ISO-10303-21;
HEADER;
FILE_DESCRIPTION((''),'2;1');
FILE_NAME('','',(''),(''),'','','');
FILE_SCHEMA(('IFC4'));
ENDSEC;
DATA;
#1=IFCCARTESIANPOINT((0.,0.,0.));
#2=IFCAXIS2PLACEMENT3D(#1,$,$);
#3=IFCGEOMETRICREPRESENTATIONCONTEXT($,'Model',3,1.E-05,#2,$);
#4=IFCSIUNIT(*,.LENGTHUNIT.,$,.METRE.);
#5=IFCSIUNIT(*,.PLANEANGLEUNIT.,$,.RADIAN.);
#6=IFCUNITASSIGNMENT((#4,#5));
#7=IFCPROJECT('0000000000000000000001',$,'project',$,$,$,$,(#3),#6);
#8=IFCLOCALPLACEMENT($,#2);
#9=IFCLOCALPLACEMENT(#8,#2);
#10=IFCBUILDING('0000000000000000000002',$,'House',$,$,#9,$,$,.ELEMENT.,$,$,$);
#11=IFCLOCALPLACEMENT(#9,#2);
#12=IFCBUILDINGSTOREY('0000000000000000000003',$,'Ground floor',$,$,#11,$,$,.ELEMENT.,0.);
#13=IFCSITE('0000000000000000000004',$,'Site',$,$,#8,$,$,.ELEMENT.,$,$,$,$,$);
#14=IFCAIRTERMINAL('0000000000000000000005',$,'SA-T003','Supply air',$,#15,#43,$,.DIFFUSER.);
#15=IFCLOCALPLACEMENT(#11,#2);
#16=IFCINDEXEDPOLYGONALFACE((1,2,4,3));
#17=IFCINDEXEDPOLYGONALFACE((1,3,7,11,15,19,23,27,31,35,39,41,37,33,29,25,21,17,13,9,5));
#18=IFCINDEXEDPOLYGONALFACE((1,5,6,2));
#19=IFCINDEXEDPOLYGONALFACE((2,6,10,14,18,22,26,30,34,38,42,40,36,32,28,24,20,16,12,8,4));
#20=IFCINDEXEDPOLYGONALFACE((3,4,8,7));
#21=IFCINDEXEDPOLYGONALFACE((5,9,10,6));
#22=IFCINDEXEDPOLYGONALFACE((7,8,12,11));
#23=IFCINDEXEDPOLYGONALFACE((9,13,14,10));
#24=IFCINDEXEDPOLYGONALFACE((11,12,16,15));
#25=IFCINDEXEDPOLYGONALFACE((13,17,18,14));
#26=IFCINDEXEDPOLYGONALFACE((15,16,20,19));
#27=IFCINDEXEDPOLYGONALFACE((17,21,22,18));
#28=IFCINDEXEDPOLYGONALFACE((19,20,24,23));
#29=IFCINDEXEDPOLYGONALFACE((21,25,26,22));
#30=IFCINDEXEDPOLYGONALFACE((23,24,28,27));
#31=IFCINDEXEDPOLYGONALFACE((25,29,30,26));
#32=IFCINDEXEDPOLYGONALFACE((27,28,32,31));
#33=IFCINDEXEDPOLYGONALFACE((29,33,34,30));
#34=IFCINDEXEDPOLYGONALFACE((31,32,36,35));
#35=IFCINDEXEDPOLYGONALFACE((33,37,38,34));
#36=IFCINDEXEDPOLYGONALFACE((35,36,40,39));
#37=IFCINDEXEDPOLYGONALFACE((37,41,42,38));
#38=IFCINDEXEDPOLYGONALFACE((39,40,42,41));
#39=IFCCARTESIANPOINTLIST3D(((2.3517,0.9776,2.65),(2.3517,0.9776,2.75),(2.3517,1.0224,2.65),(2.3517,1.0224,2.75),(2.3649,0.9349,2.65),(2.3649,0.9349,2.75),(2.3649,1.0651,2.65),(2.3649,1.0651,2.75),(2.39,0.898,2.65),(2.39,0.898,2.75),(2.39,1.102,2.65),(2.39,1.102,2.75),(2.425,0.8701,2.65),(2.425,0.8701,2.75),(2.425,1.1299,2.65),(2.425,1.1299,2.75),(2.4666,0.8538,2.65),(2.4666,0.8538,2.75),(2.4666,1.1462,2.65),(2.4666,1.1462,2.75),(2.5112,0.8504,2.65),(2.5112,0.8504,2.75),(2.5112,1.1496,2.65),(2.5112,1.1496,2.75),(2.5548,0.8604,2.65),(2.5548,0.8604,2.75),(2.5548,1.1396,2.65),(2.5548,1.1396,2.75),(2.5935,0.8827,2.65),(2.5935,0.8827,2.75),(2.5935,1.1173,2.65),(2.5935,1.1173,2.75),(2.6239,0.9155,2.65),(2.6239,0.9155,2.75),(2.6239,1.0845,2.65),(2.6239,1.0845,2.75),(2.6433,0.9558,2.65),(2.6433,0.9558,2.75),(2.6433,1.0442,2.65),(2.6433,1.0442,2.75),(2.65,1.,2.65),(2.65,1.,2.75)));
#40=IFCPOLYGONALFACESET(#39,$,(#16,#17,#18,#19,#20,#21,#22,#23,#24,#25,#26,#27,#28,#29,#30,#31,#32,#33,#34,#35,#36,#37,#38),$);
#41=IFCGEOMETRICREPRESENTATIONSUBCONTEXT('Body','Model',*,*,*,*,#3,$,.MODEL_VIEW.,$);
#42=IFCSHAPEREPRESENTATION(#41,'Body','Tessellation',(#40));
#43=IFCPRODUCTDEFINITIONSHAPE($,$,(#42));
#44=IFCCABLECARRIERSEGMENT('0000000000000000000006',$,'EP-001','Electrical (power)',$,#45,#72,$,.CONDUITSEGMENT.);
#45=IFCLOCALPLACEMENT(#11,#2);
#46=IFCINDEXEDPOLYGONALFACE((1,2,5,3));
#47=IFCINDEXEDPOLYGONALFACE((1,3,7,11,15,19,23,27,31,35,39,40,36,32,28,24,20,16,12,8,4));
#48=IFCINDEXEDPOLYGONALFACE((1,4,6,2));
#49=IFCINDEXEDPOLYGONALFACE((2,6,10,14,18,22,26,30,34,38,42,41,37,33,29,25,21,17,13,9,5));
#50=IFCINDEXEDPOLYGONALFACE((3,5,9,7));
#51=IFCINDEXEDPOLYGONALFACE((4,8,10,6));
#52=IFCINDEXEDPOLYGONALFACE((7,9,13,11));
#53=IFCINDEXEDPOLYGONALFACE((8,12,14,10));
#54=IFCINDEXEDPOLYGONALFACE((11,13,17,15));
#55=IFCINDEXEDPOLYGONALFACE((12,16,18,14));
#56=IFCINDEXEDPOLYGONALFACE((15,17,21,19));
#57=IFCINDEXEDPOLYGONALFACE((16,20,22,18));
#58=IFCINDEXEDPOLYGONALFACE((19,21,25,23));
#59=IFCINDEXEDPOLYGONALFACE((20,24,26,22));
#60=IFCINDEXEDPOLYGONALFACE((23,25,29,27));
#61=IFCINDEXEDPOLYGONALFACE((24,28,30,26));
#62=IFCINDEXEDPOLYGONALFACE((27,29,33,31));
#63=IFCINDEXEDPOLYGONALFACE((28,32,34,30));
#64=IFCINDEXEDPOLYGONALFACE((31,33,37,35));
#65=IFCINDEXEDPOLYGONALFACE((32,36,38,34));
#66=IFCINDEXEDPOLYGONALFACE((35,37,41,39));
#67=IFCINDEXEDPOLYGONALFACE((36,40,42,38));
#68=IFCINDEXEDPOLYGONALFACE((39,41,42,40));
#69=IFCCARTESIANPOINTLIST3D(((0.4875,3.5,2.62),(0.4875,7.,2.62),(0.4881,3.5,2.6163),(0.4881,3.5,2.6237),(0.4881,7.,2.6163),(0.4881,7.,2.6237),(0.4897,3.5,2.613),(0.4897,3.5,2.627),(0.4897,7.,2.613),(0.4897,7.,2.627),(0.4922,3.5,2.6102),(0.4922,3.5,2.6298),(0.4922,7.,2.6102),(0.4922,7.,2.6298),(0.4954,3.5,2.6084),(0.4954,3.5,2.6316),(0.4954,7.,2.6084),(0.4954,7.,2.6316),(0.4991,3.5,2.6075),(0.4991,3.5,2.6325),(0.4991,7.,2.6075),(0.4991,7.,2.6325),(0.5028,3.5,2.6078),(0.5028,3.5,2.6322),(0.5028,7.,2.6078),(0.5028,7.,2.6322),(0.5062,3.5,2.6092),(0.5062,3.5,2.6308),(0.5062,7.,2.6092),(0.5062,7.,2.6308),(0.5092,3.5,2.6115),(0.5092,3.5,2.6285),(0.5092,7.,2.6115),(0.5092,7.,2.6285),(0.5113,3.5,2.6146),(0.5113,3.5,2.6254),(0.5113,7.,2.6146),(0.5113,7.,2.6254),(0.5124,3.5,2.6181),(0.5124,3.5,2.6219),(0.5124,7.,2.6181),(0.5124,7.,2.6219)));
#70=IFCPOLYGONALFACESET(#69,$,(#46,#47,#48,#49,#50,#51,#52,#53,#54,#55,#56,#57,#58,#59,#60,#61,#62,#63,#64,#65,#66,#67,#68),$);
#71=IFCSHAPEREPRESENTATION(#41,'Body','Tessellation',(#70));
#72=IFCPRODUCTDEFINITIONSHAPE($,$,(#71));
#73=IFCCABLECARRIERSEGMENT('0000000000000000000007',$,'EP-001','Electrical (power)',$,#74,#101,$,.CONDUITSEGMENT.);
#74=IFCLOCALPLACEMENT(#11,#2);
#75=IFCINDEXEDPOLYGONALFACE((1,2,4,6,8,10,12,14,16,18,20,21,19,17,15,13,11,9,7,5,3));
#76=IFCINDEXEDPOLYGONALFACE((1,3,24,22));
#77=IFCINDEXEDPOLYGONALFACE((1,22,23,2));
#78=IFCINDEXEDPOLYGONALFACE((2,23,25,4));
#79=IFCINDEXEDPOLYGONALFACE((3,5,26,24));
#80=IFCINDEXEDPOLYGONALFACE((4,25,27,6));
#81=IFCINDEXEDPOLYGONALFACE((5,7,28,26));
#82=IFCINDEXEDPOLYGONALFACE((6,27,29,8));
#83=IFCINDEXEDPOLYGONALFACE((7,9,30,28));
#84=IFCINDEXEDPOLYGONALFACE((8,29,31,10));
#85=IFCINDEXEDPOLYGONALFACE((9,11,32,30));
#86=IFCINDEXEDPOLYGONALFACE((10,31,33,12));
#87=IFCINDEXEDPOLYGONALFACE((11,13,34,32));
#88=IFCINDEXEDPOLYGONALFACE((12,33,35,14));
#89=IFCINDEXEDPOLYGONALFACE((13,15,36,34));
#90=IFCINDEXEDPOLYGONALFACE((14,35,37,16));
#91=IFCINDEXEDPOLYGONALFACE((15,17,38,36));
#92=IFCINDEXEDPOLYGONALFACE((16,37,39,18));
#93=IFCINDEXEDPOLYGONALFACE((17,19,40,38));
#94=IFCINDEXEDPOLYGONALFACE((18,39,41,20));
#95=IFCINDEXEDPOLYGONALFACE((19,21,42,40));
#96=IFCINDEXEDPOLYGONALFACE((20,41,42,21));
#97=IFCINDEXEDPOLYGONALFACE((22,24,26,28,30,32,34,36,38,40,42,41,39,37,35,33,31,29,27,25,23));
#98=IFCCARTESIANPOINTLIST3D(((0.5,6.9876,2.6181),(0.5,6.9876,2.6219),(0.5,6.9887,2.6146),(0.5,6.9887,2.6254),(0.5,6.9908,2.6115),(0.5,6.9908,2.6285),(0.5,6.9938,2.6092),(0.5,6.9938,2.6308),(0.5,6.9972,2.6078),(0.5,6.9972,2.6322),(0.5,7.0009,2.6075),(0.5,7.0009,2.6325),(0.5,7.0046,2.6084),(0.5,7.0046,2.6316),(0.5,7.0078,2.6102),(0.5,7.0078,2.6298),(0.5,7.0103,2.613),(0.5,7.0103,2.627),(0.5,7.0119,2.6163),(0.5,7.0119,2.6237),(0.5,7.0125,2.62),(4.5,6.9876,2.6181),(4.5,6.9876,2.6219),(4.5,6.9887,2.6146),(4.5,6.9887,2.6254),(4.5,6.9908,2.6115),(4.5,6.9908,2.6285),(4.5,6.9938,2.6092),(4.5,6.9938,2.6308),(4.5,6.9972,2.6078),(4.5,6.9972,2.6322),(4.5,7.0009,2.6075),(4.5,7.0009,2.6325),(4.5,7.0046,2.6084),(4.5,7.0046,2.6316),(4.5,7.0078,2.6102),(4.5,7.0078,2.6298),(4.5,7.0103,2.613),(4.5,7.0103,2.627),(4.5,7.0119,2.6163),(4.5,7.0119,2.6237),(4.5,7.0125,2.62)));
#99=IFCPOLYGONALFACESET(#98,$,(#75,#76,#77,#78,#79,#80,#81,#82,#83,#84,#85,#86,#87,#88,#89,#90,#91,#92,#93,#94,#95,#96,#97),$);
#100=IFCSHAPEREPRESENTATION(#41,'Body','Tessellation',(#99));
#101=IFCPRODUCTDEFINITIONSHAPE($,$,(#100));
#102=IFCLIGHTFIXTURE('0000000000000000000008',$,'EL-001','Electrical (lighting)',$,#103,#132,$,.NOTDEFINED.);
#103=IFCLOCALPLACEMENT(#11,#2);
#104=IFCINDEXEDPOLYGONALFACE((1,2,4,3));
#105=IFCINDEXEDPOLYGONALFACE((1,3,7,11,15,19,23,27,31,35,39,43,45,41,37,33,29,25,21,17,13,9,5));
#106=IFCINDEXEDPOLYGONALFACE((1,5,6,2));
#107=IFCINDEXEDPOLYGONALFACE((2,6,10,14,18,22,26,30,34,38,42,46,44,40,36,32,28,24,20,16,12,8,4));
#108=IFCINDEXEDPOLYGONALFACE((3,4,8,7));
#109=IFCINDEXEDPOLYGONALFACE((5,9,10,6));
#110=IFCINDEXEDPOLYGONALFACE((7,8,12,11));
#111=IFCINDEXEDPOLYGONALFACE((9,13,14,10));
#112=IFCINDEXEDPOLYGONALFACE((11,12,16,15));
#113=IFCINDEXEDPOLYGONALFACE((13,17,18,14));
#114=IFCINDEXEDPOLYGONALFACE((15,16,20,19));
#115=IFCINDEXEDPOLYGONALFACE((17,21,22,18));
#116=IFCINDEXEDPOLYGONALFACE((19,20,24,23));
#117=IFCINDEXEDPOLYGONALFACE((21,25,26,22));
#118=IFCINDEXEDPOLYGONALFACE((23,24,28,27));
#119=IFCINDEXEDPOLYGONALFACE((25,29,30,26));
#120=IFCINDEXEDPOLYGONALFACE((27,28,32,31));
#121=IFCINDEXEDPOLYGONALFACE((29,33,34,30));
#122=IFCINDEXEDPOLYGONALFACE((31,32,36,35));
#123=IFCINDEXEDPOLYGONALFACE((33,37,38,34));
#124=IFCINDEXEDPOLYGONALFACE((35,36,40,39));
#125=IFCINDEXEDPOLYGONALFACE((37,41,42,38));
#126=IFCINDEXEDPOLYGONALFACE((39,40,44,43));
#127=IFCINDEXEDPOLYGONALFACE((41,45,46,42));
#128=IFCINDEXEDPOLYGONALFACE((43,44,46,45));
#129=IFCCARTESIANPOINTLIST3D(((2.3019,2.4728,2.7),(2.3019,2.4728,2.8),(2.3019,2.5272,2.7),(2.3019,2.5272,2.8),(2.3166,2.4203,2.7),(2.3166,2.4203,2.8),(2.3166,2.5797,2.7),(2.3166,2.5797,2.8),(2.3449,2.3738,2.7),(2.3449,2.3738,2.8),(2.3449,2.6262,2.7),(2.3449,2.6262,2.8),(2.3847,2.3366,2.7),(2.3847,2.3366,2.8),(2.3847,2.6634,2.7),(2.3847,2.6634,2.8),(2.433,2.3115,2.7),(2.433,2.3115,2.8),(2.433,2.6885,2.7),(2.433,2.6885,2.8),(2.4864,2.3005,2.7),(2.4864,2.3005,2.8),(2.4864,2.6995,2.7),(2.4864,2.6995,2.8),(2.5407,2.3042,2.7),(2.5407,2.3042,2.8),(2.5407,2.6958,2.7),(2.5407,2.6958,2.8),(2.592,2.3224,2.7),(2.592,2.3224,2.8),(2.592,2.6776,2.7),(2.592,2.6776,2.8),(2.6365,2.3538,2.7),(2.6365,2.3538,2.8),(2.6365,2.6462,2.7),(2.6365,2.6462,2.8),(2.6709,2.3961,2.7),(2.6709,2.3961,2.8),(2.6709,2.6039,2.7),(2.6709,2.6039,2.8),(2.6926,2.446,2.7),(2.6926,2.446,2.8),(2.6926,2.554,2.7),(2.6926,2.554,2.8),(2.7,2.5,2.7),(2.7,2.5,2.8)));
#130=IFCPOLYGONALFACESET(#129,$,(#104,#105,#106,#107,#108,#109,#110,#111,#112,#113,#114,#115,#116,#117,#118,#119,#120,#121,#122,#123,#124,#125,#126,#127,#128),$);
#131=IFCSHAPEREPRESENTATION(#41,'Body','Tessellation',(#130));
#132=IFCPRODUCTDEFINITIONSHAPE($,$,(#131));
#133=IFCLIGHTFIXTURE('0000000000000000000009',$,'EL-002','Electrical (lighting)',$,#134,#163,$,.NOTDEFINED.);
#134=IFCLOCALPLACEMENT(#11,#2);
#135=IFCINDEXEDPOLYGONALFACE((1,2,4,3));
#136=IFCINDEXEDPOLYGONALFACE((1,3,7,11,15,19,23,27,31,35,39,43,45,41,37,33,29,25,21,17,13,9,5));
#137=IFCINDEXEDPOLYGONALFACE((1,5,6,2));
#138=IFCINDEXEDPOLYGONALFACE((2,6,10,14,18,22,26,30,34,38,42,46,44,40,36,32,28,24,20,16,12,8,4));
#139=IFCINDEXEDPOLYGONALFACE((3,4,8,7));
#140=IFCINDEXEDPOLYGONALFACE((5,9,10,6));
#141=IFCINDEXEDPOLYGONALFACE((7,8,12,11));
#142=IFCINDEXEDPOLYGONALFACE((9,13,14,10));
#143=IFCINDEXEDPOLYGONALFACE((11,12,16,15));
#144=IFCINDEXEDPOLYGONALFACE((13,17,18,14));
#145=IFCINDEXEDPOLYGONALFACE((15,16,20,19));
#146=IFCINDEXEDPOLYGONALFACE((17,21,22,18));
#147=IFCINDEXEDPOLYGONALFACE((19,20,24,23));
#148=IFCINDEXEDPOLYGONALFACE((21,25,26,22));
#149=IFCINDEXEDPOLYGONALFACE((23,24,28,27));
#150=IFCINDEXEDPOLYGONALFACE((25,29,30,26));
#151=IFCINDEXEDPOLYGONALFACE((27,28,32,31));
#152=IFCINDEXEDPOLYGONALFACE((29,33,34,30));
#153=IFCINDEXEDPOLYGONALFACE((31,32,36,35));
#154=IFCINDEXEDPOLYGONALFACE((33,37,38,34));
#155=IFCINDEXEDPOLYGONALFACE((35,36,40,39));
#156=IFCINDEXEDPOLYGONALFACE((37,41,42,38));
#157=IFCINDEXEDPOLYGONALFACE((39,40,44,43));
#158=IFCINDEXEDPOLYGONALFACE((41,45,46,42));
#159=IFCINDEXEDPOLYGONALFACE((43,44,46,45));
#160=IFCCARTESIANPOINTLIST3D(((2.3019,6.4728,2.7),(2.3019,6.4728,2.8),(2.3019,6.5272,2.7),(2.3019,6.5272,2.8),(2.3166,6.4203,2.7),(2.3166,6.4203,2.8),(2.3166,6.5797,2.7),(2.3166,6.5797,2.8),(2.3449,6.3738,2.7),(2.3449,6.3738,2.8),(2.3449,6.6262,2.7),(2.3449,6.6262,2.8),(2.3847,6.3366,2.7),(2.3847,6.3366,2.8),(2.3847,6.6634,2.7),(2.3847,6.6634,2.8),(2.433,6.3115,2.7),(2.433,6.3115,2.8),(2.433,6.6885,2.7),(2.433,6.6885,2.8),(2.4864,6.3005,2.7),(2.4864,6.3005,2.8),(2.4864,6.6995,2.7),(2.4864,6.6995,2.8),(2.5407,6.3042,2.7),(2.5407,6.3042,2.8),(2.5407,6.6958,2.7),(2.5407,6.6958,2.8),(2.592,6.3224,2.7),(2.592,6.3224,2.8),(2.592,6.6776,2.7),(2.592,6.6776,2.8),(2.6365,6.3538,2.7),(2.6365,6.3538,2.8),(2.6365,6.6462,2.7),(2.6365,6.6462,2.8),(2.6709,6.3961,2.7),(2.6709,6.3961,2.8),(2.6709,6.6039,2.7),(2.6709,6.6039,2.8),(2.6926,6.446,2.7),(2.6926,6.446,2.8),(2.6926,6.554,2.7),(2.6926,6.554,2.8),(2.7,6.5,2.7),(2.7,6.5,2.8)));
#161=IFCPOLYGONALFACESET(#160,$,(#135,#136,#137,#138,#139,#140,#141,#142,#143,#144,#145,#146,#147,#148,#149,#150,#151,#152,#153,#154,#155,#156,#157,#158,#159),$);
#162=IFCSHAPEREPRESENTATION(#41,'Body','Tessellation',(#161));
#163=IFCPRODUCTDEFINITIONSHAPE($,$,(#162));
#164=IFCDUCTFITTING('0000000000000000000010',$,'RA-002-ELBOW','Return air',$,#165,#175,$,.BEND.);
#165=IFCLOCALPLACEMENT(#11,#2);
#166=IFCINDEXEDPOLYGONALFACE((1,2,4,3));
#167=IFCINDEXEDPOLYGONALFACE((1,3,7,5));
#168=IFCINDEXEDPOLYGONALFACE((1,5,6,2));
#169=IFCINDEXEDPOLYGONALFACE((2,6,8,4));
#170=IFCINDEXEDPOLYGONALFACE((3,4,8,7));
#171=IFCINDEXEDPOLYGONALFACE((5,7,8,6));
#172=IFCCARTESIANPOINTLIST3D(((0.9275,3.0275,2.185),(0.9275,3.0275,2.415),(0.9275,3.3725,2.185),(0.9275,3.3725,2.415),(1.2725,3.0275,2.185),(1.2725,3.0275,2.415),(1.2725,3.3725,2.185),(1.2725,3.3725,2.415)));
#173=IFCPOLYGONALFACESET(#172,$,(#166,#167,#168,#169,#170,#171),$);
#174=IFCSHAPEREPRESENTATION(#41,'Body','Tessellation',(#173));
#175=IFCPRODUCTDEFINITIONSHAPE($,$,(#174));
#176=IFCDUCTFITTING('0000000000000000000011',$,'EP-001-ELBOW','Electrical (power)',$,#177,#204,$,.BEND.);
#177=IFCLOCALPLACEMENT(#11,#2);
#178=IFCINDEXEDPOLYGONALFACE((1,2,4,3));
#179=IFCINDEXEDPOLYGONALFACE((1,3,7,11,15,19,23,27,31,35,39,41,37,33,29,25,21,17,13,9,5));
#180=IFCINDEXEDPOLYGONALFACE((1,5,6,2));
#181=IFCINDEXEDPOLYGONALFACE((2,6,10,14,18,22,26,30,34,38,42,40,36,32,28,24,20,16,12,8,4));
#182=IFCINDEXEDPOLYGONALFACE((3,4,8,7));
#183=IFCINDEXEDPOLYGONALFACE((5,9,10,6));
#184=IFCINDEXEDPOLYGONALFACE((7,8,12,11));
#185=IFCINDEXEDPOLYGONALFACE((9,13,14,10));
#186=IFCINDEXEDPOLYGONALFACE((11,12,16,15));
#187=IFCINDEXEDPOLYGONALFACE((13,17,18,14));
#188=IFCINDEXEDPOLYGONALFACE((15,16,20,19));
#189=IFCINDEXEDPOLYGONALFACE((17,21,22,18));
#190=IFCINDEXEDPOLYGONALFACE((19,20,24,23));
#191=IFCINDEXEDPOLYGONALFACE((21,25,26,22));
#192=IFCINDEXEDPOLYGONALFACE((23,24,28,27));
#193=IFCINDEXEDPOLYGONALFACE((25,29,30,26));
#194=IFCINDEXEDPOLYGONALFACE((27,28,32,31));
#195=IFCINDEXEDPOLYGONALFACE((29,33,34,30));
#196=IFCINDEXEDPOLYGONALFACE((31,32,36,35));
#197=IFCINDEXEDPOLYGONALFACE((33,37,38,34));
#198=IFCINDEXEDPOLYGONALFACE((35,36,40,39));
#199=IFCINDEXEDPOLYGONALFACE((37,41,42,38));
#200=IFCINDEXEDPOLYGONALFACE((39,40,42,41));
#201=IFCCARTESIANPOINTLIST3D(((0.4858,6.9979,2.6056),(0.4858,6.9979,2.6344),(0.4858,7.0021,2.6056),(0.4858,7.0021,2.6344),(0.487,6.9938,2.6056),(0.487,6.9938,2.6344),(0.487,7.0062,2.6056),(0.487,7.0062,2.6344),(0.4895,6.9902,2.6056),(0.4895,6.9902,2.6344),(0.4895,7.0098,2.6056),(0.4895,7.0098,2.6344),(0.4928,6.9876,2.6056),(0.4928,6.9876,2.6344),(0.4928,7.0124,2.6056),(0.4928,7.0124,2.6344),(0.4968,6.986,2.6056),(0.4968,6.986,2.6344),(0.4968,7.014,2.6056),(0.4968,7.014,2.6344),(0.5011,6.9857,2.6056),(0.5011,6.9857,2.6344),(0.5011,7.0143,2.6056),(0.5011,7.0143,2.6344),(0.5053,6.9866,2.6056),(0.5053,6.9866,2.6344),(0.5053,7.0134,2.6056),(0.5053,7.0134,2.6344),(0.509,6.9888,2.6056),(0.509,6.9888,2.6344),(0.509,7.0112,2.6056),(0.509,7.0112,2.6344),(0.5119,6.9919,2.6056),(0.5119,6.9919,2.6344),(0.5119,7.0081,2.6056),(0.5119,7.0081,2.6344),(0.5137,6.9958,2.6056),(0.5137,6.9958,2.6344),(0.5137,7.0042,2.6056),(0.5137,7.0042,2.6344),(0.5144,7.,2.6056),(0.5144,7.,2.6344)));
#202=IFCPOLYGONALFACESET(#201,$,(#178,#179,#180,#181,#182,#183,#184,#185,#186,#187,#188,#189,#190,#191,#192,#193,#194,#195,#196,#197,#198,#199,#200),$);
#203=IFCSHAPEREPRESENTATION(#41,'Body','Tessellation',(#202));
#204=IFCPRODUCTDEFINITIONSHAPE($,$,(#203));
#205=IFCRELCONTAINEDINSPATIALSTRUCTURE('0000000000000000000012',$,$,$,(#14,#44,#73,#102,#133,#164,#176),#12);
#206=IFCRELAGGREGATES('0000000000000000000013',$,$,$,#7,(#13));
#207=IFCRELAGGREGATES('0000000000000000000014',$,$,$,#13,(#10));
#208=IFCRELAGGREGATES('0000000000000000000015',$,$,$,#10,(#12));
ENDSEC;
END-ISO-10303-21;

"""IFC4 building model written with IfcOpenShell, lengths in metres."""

from ifc_helpers import new_model, si_unit, frame, origin, origin_2d, place, context, subcontext, project, spatial, rectangle, circle, extrude, element, save


model = new_model("IFC4")

# Units and contexts
model_context = context("Model", 3, precision=1e-05, world=origin())
body_context = subcontext(model_context, "Body", "Model", "MODEL_VIEW")
ifc_project = project(units=[si_unit("LENGTHUNIT", "METRE"), si_unit("PLANEANGLEUNIT", "RADIAN")], contexts=[model_context])

# Site, building, storey
site_placement = place(None, origin())
site = spatial("IfcSite", under=ifc_project, at=site_placement, Name="Site", CompositionType="ELEMENT")
building_placement = place(site_placement, origin())
building = spatial("IfcBuilding", under=site, at=building_placement, Name="House", CompositionType="ELEMENT")
storey_placement = place(building_placement, origin())
storey = spatial("IfcBuildingStorey", under=building, at=storey_placement, Name="Ground floor", CompositionType="ELEMENT", Elevation=0.0)

# Air terminal
air_terminal_placement = place(storey_placement, frame((2.5, 1.0, 2.65), z_axis=(0.0, 0.0, 1.0), x_axis=(1.0, 0.0, 0.0)))
element("IfcAirTerminal", 1, at=air_terminal_placement, inside=storey, Name="SA-T003", Description="Supply air", PredefinedType="DIFFUSER", context=body_context, shape_type="SweptSolid", body=[
    extrude(circle(Radius=0.15, at=origin_2d()), origin(), (0.0, 0.0, 1.0), 0.1),
])

# Cable carrier segments
cable_carrier_segment_1_placement = place(storey_placement, frame((0.5, 3.5, 2.62), z_axis=(0.0, 1.0, 0.0), x_axis=(-1.0, 0.0, 0.0)))
element("IfcCableCarrierSegment", 2, at=cable_carrier_segment_1_placement, inside=storey, Name="EP-001", Description="Electrical (power)", PredefinedType="CONDUITSEGMENT", context=body_context, shape_type="SweptSolid", body=[
    extrude(circle(Radius=0.0125, at=origin_2d()), origin(), (0.0, 0.0, 1.0), 3.5),
])
cable_carrier_segment_2_placement = place(storey_placement, frame((0.5, 7.0, 2.62), z_axis=(1.0, 0.0, 0.0), x_axis=(0.0, 1.0, 0.0)))
element("IfcCableCarrierSegment", 3, at=cable_carrier_segment_2_placement, inside=storey, Name="EP-001", Description="Electrical (power)", PredefinedType="CONDUITSEGMENT", context=body_context, shape_type="SweptSolid", body=[
    extrude(circle(Radius=0.0125, at=origin_2d()), origin(), (0.0, 0.0, 1.0), 4.0),
])

# Light fixtures
for number, where, z_axis, x_axis, name in (
    (4, (2.5, 2.5, 2.7), (0.0, 0.0, 1.0), (1.0, 0.0, 0.0), "EL-001"),
    (5, (2.5, 6.5, 2.7), (0.0, 0.0, 1.0), (1.0, 0.0, 0.0), "EL-002"),
):
    element("IfcLightFixture", number, at=place(storey_placement, frame(where, z_axis=z_axis, x_axis=x_axis)), inside=storey, Name=name, Description="Electrical (lighting)", PredefinedType="NOTDEFINED", context=body_context, shape_type="SweptSolid", body=[
        extrude(circle(Radius=0.2, at=origin_2d()), origin(), (0.0, 0.0, 1.0), 0.1),
    ])

# Duct fittings
duct_fitting_1_placement = place(storey_placement, frame((1.1, 3.2, 2.185), z_axis=(0.0, 0.0, 1.0), x_axis=(1.0, 0.0, 0.0)))
element("IfcDuctFitting", 6, at=duct_fitting_1_placement, inside=storey, Name="RA-002-ELBOW", Description="Return air", PredefinedType="BEND", context=body_context, shape_type="SweptSolid", body=[
    extrude(rectangle(XDim=0.345, YDim=0.345, at=origin_2d()), origin(), (0.0, 0.0, 1.0), 0.23),
])
duct_fitting_2_placement = place(storey_placement, frame((0.5, 7.0, 2.6056), z_axis=(0.0, 0.0, 1.0), x_axis=(1.0, 0.0, 0.0)))
element("IfcDuctFitting", 7, at=duct_fitting_2_placement, inside=storey, Name="EP-001-ELBOW", Description="Electrical (power)", PredefinedType="BEND", context=body_context, shape_type="SweptSolid", body=[
    extrude(circle(Radius=0.0144, at=origin_2d()), origin(), (0.0, 0.0, 1.0), 0.0288),
])

save(model, "model.ifc")
